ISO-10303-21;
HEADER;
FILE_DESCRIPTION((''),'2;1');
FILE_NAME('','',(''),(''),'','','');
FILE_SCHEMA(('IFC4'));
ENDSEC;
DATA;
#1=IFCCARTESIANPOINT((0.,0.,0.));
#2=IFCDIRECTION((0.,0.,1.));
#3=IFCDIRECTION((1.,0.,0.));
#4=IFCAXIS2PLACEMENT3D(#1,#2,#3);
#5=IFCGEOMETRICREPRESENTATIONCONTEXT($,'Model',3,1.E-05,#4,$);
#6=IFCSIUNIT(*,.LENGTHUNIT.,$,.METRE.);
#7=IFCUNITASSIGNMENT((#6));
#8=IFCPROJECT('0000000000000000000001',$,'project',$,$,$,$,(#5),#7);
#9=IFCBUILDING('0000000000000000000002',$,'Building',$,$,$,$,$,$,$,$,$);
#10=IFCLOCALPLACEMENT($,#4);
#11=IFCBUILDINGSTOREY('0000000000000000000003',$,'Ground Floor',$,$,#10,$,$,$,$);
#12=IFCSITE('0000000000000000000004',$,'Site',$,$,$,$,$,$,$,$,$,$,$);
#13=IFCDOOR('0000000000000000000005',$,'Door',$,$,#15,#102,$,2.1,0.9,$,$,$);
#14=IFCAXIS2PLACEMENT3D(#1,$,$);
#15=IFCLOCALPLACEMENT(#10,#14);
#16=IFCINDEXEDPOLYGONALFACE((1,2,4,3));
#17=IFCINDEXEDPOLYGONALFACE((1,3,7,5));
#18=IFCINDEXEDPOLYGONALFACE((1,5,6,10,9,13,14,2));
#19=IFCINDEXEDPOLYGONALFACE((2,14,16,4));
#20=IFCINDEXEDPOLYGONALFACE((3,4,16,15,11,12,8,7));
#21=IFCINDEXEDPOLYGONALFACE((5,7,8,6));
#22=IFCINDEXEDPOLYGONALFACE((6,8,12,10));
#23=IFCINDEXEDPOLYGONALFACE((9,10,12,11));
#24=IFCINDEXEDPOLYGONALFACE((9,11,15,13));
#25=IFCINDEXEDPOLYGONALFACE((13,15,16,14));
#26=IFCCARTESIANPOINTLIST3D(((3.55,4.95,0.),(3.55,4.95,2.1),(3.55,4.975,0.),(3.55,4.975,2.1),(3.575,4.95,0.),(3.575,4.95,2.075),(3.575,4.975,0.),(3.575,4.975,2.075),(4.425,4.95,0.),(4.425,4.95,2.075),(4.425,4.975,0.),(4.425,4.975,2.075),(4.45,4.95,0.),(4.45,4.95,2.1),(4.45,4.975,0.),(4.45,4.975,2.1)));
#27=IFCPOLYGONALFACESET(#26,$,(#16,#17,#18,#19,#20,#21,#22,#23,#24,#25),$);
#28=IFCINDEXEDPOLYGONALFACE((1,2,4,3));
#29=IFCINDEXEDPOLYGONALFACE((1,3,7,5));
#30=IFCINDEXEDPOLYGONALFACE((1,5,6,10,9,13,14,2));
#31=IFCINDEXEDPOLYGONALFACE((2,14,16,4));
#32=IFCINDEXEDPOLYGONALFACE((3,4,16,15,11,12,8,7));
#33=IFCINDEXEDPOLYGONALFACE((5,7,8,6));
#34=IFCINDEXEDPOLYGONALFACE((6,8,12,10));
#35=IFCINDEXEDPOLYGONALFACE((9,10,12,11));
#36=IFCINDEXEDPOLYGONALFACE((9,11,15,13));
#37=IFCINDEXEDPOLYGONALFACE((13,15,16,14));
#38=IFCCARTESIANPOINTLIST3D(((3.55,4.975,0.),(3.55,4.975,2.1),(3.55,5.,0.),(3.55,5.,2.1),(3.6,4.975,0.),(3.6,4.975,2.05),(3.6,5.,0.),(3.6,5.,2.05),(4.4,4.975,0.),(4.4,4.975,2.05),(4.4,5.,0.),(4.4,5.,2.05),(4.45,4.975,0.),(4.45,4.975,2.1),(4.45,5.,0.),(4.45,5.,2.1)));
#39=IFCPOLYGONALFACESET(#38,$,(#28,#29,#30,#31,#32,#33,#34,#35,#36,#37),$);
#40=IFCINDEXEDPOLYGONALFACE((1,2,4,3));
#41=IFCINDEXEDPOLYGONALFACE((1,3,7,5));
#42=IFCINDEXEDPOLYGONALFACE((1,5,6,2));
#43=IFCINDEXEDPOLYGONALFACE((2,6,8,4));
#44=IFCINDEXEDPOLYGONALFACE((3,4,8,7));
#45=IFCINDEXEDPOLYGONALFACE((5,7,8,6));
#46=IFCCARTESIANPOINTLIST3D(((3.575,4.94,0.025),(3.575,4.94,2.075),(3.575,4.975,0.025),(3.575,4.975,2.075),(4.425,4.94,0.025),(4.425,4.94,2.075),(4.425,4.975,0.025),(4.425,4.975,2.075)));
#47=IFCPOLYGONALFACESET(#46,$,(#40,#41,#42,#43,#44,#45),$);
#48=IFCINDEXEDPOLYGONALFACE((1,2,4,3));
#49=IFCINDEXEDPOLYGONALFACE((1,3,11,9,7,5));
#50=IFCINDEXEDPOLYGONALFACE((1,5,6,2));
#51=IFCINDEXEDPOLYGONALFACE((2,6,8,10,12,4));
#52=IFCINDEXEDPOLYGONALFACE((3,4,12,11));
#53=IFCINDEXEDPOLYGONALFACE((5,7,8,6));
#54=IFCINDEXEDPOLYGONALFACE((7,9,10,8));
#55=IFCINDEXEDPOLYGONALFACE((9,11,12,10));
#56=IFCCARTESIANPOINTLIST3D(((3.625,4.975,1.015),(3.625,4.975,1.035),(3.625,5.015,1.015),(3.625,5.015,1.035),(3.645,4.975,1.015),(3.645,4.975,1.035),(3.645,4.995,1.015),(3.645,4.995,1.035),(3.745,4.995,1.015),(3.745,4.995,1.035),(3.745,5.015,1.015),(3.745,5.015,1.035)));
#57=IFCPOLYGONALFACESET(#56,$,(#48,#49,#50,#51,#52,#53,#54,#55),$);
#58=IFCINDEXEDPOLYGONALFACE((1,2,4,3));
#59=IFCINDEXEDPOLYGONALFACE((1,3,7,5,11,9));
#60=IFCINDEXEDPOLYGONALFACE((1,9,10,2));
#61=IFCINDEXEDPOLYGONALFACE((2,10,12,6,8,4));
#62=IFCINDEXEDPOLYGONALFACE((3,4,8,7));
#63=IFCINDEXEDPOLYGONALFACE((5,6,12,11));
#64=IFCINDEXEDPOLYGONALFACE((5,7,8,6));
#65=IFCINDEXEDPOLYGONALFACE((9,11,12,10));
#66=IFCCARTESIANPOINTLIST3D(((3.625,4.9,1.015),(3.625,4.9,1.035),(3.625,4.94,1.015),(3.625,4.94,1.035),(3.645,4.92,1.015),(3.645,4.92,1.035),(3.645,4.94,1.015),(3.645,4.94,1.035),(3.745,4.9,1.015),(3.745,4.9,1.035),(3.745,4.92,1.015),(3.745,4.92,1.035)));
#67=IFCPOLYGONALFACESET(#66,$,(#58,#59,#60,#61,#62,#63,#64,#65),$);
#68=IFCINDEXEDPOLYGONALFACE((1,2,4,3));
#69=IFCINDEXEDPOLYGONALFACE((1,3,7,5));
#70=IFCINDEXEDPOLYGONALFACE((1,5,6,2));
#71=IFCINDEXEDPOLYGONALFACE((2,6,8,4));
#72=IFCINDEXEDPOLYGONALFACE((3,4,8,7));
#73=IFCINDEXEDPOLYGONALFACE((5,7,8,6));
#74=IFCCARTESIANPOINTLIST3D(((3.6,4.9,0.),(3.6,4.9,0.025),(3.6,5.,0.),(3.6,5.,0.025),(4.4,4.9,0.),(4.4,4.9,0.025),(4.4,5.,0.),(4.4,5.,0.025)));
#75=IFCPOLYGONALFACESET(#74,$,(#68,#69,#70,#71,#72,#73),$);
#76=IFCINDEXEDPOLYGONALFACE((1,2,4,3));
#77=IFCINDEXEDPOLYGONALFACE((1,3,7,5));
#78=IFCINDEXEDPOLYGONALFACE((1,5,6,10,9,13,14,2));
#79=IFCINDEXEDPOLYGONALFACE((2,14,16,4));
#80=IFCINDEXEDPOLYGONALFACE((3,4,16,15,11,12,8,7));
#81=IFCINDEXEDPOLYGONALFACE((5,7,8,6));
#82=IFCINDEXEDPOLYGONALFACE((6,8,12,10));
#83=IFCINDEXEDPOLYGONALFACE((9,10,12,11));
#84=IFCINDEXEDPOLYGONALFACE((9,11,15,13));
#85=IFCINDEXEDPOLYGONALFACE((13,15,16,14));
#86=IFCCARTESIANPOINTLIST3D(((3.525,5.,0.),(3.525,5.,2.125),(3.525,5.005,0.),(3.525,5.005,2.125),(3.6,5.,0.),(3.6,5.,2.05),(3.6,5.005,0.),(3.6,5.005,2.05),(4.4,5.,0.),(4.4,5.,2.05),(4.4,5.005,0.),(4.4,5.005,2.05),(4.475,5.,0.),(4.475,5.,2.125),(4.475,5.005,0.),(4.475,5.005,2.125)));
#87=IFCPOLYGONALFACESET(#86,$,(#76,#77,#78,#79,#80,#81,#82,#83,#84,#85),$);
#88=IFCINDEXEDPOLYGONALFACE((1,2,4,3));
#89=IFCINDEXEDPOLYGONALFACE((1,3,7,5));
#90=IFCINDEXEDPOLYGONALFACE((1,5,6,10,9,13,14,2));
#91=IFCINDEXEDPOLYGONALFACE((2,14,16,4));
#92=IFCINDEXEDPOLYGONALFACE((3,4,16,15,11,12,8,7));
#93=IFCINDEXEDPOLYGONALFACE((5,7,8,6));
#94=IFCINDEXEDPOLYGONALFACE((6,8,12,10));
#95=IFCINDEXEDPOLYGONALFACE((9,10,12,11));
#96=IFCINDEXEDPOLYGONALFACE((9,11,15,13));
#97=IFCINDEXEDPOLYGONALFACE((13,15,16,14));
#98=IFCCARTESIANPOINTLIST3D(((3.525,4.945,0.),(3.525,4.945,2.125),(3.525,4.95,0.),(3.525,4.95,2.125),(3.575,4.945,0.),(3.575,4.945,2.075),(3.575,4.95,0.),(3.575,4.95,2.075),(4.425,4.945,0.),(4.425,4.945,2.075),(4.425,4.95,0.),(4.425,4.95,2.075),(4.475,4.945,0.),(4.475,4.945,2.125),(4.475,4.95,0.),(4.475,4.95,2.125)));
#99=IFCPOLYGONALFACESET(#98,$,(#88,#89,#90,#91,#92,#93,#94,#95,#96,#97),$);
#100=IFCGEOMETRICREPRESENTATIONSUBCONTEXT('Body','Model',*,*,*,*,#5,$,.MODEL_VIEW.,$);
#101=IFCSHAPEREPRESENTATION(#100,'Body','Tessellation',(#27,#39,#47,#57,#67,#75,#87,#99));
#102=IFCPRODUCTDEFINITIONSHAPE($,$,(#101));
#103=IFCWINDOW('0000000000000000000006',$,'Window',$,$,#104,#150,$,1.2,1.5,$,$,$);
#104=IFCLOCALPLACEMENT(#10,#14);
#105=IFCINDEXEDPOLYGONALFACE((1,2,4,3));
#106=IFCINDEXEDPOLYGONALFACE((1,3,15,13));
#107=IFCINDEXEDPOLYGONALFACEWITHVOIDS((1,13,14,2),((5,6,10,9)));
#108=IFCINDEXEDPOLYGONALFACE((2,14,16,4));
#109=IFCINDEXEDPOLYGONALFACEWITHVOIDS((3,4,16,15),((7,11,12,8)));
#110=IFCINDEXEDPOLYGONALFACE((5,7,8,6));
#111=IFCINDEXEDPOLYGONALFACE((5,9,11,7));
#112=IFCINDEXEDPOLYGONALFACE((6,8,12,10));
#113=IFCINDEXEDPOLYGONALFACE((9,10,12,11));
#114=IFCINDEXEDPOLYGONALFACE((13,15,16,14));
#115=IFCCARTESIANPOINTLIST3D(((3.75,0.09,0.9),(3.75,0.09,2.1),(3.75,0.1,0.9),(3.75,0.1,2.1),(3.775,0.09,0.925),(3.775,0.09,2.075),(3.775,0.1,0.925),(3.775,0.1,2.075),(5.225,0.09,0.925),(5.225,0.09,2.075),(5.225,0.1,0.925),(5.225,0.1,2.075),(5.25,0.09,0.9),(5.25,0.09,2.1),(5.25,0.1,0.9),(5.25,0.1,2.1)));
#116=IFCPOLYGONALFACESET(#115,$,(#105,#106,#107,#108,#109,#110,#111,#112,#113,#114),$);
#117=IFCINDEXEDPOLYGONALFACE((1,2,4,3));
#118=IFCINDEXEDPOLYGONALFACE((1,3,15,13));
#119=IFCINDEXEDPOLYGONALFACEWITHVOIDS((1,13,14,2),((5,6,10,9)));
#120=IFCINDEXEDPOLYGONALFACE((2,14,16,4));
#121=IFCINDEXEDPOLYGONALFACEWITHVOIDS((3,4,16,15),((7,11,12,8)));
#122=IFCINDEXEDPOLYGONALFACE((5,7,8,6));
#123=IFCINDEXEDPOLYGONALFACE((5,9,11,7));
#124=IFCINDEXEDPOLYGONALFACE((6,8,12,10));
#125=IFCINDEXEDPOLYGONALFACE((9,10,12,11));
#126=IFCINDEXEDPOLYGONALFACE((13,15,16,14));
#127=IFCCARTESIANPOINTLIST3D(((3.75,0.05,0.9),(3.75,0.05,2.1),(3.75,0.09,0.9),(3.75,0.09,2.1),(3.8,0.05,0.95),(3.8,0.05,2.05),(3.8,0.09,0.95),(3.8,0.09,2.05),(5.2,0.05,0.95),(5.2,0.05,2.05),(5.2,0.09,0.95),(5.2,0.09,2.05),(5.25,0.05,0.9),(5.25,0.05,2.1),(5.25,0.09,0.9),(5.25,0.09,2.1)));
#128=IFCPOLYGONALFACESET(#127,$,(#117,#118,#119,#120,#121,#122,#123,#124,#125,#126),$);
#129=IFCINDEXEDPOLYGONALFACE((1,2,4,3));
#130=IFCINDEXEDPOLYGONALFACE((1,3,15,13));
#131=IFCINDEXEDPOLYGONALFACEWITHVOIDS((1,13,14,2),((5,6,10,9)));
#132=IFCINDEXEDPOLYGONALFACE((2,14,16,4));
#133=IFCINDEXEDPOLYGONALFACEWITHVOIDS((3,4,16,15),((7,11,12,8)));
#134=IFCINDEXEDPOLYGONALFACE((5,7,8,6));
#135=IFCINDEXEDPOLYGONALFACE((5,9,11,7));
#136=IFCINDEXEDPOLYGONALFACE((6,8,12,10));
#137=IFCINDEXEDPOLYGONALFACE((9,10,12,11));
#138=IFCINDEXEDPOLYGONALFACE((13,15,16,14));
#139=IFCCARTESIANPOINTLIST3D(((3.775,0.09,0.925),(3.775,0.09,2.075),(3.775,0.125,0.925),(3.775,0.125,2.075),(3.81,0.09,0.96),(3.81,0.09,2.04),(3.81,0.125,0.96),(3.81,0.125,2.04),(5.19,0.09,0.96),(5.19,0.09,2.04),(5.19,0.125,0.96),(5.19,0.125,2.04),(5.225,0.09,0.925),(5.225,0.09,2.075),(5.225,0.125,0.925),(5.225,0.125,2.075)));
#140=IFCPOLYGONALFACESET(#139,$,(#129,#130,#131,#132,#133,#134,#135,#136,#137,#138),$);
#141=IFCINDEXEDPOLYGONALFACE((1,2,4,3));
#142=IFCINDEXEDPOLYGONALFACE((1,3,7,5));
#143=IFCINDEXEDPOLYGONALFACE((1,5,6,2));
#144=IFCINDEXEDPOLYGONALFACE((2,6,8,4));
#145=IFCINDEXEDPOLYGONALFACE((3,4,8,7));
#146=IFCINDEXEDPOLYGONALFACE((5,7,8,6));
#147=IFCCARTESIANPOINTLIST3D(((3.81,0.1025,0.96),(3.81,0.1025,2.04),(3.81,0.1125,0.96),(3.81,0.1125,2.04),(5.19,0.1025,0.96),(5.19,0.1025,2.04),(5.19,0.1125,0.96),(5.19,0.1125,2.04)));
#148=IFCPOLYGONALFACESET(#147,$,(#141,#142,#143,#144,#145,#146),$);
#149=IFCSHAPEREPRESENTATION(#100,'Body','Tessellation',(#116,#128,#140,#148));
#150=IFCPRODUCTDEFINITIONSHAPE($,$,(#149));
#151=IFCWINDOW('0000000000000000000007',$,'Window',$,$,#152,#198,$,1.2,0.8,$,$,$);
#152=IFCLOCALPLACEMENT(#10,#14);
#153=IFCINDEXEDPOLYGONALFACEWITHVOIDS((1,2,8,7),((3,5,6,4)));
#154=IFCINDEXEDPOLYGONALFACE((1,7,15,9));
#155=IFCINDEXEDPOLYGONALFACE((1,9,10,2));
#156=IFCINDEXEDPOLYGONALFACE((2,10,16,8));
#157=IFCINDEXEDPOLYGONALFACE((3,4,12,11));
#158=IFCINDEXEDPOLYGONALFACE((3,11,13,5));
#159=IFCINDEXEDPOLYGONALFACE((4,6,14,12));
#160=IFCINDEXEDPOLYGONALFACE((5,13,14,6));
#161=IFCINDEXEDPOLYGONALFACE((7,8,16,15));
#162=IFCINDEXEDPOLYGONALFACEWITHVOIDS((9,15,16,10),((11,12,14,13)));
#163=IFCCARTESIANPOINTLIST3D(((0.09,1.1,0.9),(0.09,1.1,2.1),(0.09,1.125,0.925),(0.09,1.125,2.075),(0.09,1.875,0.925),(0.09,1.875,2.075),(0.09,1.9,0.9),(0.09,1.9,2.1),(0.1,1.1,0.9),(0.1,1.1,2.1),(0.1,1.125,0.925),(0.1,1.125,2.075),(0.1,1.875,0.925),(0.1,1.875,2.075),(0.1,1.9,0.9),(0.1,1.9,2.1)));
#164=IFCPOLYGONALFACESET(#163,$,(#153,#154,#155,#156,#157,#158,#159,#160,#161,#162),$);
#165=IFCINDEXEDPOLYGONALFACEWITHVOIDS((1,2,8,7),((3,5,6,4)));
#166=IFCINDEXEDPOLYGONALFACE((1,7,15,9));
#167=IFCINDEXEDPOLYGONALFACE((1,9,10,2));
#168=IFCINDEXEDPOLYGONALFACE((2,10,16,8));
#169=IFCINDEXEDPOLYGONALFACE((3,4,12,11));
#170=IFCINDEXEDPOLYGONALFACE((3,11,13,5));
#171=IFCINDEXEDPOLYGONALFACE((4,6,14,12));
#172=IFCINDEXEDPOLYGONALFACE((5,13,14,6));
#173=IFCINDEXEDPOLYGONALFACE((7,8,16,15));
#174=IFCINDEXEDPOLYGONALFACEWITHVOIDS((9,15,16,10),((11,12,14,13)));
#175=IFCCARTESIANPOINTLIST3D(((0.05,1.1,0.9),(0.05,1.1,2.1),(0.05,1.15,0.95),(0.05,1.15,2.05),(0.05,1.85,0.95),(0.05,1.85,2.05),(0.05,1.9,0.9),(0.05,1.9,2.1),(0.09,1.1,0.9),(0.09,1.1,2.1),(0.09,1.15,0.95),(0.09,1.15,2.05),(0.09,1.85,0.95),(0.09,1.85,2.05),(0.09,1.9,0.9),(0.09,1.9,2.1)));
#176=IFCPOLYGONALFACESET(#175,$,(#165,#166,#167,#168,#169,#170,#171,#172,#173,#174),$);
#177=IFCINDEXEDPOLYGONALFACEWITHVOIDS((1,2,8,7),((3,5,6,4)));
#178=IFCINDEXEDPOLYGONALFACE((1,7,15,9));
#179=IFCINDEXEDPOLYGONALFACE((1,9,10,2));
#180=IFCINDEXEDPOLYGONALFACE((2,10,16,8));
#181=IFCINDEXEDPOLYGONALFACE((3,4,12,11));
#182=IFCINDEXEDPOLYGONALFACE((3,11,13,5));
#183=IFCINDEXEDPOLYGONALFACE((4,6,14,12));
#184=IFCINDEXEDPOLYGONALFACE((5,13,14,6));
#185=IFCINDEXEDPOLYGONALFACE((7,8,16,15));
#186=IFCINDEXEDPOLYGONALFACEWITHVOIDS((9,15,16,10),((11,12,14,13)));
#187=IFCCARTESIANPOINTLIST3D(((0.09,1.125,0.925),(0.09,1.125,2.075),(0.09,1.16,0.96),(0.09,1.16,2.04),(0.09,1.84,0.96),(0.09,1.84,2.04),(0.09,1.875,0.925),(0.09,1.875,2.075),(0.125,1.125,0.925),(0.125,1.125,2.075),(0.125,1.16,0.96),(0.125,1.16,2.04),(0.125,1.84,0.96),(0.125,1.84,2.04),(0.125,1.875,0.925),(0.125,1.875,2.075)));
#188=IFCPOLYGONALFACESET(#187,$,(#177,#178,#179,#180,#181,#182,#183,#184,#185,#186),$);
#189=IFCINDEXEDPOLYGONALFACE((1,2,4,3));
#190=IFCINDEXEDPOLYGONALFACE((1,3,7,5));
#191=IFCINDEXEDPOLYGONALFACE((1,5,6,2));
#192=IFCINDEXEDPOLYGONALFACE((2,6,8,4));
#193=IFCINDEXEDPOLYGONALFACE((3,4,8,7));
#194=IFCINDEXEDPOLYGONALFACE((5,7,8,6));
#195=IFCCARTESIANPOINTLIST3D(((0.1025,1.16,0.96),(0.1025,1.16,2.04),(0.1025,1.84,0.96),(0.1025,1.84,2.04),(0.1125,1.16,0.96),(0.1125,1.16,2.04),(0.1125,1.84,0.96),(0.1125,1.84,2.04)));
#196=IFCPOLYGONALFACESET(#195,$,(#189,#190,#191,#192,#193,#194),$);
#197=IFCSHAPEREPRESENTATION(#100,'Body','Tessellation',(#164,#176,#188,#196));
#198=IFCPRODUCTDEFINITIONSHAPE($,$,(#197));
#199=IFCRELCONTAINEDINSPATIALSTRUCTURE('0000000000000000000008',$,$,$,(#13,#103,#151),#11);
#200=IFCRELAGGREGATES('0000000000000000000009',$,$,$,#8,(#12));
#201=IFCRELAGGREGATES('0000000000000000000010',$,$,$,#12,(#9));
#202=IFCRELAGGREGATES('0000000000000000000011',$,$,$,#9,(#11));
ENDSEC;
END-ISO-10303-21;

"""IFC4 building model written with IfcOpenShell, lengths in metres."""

from ifc_helpers import new_model, si_unit, frame, origin_with_axes, place, context, subcontext, project, spatial, line, indexed_curve, outline, extrude, element, save


model = new_model("IFC4")

# Units and contexts
model_context = context("Model", 3, precision=1e-05, world=origin_with_axes())
body_context = subcontext(model_context, "Body", "Model", "MODEL_VIEW")
ifc_project = project(units=[si_unit("LENGTHUNIT", "METRE")], contexts=[model_context])

# Site, building, storey
site = spatial("IfcSite", under=ifc_project, Name="Site")
building = spatial("IfcBuilding", under=site, Name="Building")
storey_placement = place(None, origin_with_axes())
storey = spatial("IfcBuildingStorey", under=building, at=storey_placement, Name="Ground Floor")

# Door
door_1_placement = place(storey_placement, frame((4.45, 5.0, 0.0), z_axis=(0.0, 0.0, 1.0), x_axis=(-1.0, 0.0, 0.0)))
element("IfcDoor", 1, at=door_1_placement, inside=storey, Name="Door", OverallHeight=2.1, OverallWidth=0.9, context=body_context, shape_type="SweptSolid", body=[
    extrude(outline(indexed_curve([(0.0, 0.0), (0.0, 2.1), (0.9, 2.1), (0.9, 0.0), (0.875, 0.0), (0.875, 2.075), (0.025, 2.075), (0.025, 0.0)], segments=[line(1, 2, 3, 4, 5, 6, 7, 8, 1)])), frame((0.0, 0.025, 0.0), z_axis=(0.0, -1.0, 0.0), x_axis=(1.0, 0.0, 0.0)), (0.0, 0.0, -1.0), 0.025),
    extrude(outline(indexed_curve([(0.0, 0.0), (0.0, 2.1), (0.9, 2.1), (0.9, 0.0), (0.85, 0.0), (0.85, 2.05), (0.05, 2.05), (0.05, 0.0)], segments=[line(1, 2, 3, 4, 5, 6, 7, 8, 1)])), frame((0.0, 0.0, 0.0), z_axis=(0.0, -1.0, 0.0), x_axis=(1.0, 0.0, 0.0)), (0.0, 0.0, -1.0), 0.025),
    extrude(outline(indexed_curve([(0.0, 0.0), (0.85, 0.0), (0.85, 0.035), (0.0, 0.035)], segments=[line(1, 2, 3, 4, 1)])), frame((0.025, 0.025, 0.025), z_axis=(0.0, 0.0, 1.0), x_axis=(1.0, 0.0, 0.0)), (0.0, 0.0, 1.0), 2.05),
    extrude(outline(indexed_curve([(0.0, 0.0), (0.0, -0.04), (-0.12, -0.04), (-0.12, -0.02), (-0.02, -0.02), (-0.02, 0.0)], segments=[line(1, 2, 3, 4, 5, 6, 1)])), frame((0.825, 0.025, 1.015), z_axis=(0.0, 0.0, 1.0), x_axis=(1.0, 0.0, 0.0)), (0.0, 0.0, 1.0), 0.02),
    extrude(outline(indexed_curve([(0.0, 0.0), (0.0, 0.04), (-0.12, 0.04), (-0.12, 0.02), (-0.02, 0.02), (-0.02, 0.0)], segments=[line(1, 2, 3, 4, 5, 6, 1)])), frame((0.825, 0.06, 1.015), z_axis=(0.0, 0.0, 1.0), x_axis=(1.0, 0.0, 0.0)), (0.0, 0.0, 1.0), 0.02),
    extrude(outline(indexed_curve([(0.0, 0.0), (0.8, 0.0), (0.8, 0.1), (0.0, 0.1)], segments=[line(1, 2, 3, 4, 1)])), frame((0.05, 0.0, 0.0), z_axis=(0.0, 0.0, 1.0), x_axis=(1.0, 0.0, 0.0)), (0.0, 0.0, 1.0), 0.025),
    extrude(outline(indexed_curve([(0.0, 0.0), (0.0, 2.125), (0.95, 2.125), (0.95, 0.0), (0.875, 0.0), (0.875, 2.05), (0.075, 2.05), (0.075, 0.0)], segments=[line(1, 2, 3, 4, 5, 6, 7, 8, 1)])), frame((-0.025, -0.005, 0.0), z_axis=(0.0, -1.0, 0.0), x_axis=(1.0, 0.0, 0.0)), (0.0, 0.0, -1.0), 0.005),
    extrude(outline(indexed_curve([(0.0, 0.0), (0.0, 2.125), (0.95, 2.125), (0.95, 0.0), (0.9, 0.0), (0.9, 2.075), (0.05, 2.075), (0.05, 0.0)], segments=[line(1, 2, 3, 4, 5, 6, 7, 8, 1)])), frame((-0.025, 0.05, 0.0), z_axis=(0.0, -1.0, 0.0), x_axis=(1.0, 0.0, 0.0)), (0.0, 0.0, -1.0), 0.005),
])

# Windows
window_1_placement = place(storey_placement, frame((3.75, 0.0, 0.9), z_axis=(0.0, 0.0, 1.0), x_axis=(1.0, 0.0, 0.0)))
element("IfcWindow", 2, at=window_1_placement, inside=storey, Name="Window", OverallHeight=1.2, OverallWidth=1.5, context=body_context, shape_type="SweptSolid", body=[
    extrude(outline(indexed_curve([(0.0, 0.0), (1.5, 0.0), (1.5, 1.2), (0.0, 1.2)], segments=[line(1, 2, 3, 4, 1)]), holes=[indexed_curve([(0.025, 0.025), (1.475, 0.025), (1.475, 1.175), (0.025, 1.175)], segments=[line(1, 2, 3, 4, 1)])]), frame((0.0, 0.09, 0.0), z_axis=(0.0, -1.0, 0.0), x_axis=(1.0, 0.0, 0.0)), (0.0, 0.0, -1.0), 0.01),
    extrude(outline(indexed_curve([(0.0, 0.0), (1.5, 0.0), (1.5, 1.2), (0.0, 1.2)], segments=[line(1, 2, 3, 4, 1)]), holes=[indexed_curve([(0.05, 0.05), (1.45, 0.05), (1.45, 1.15), (0.05, 1.15)], segments=[line(1, 2, 3, 4, 1)])]), frame((0.0, 0.05, 0.0), z_axis=(0.0, -1.0, 0.0), x_axis=(1.0, 0.0, 0.0)), (0.0, 0.0, -1.0), 0.04),
    extrude(outline(indexed_curve([(0.0, 0.0), (1.45, 0.0), (1.45, 1.15), (0.0, 1.15)], segments=[line(1, 2, 3, 4, 1)]), holes=[indexed_curve([(0.035, 0.035), (1.415, 0.035), (1.415, 1.115), (0.035, 1.115)], segments=[line(1, 2, 3, 4, 1)])]), frame((0.025, 0.09, 0.025), z_axis=(0.0, -1.0, 0.0), x_axis=(1.0, 0.0, 0.0)), (0.0, 0.0, -1.0), 0.035),
    extrude(outline(indexed_curve([(0.035, 0.035), (1.415, 0.035), (1.415, 1.115), (0.035, 1.115)], segments=[line(1, 2, 3, 4, 1)])), frame((0.025, 0.1025, 0.025), z_axis=(0.0, -1.0, 0.0), x_axis=(1.0, 0.0, 0.0)), (0.0, 0.0, -1.0), 0.01),
])
window_2_placement = place(storey_placement, frame((0.0, 1.9, 0.9), z_axis=(0.0, 0.0, 1.0), x_axis=(0.0, -1.0, 0.0)))
element("IfcWindow", 3, at=window_2_placement, inside=storey, Name="Window", OverallHeight=1.2, OverallWidth=0.8, context=body_context, shape_type="SweptSolid", body=[
    extrude(outline(indexed_curve([(0.0, 0.0), (0.8, 0.0), (0.8, 1.2), (0.0, 1.2)], segments=[line(1, 2, 3, 4, 1)]), holes=[indexed_curve([(0.025, 0.025), (0.775, 0.025), (0.775, 1.175), (0.025, 1.175)], segments=[line(1, 2, 3, 4, 1)])]), frame((0.0, 0.09, 0.0), z_axis=(0.0, -1.0, 0.0), x_axis=(1.0, 0.0, 0.0)), (0.0, 0.0, -1.0), 0.01),
    extrude(outline(indexed_curve([(0.0, 0.0), (0.8, 0.0), (0.8, 1.2), (0.0, 1.2)], segments=[line(1, 2, 3, 4, 1)]), holes=[indexed_curve([(0.05, 0.05), (0.75, 0.05), (0.75, 1.15), (0.05, 1.15)], segments=[line(1, 2, 3, 4, 1)])]), frame((0.0, 0.05, 0.0), z_axis=(0.0, -1.0, 0.0), x_axis=(1.0, 0.0, 0.0)), (0.0, 0.0, -1.0), 0.04),
    extrude(outline(indexed_curve([(0.0, 0.0), (0.75, 0.0), (0.75, 1.15), (0.0, 1.15)], segments=[line(1, 2, 3, 4, 1)]), holes=[indexed_curve([(0.035, 0.035), (0.715, 0.035), (0.715, 1.115), (0.035, 1.115)], segments=[line(1, 2, 3, 4, 1)])]), frame((0.025, 0.09, 0.025), z_axis=(0.0, -1.0, 0.0), x_axis=(1.0, 0.0, 0.0)), (0.0, 0.0, -1.0), 0.035),
    extrude(outline(indexed_curve([(0.035, 0.035), (0.715, 0.035), (0.715, 1.115), (0.035, 1.115)], segments=[line(1, 2, 3, 4, 1)])), frame((0.025, 0.1025, 0.025), z_axis=(0.0, -1.0, 0.0), x_axis=(1.0, 0.0, 0.0)), (0.0, 0.0, -1.0), 0.01),
])

save(model, "model.ifc")
